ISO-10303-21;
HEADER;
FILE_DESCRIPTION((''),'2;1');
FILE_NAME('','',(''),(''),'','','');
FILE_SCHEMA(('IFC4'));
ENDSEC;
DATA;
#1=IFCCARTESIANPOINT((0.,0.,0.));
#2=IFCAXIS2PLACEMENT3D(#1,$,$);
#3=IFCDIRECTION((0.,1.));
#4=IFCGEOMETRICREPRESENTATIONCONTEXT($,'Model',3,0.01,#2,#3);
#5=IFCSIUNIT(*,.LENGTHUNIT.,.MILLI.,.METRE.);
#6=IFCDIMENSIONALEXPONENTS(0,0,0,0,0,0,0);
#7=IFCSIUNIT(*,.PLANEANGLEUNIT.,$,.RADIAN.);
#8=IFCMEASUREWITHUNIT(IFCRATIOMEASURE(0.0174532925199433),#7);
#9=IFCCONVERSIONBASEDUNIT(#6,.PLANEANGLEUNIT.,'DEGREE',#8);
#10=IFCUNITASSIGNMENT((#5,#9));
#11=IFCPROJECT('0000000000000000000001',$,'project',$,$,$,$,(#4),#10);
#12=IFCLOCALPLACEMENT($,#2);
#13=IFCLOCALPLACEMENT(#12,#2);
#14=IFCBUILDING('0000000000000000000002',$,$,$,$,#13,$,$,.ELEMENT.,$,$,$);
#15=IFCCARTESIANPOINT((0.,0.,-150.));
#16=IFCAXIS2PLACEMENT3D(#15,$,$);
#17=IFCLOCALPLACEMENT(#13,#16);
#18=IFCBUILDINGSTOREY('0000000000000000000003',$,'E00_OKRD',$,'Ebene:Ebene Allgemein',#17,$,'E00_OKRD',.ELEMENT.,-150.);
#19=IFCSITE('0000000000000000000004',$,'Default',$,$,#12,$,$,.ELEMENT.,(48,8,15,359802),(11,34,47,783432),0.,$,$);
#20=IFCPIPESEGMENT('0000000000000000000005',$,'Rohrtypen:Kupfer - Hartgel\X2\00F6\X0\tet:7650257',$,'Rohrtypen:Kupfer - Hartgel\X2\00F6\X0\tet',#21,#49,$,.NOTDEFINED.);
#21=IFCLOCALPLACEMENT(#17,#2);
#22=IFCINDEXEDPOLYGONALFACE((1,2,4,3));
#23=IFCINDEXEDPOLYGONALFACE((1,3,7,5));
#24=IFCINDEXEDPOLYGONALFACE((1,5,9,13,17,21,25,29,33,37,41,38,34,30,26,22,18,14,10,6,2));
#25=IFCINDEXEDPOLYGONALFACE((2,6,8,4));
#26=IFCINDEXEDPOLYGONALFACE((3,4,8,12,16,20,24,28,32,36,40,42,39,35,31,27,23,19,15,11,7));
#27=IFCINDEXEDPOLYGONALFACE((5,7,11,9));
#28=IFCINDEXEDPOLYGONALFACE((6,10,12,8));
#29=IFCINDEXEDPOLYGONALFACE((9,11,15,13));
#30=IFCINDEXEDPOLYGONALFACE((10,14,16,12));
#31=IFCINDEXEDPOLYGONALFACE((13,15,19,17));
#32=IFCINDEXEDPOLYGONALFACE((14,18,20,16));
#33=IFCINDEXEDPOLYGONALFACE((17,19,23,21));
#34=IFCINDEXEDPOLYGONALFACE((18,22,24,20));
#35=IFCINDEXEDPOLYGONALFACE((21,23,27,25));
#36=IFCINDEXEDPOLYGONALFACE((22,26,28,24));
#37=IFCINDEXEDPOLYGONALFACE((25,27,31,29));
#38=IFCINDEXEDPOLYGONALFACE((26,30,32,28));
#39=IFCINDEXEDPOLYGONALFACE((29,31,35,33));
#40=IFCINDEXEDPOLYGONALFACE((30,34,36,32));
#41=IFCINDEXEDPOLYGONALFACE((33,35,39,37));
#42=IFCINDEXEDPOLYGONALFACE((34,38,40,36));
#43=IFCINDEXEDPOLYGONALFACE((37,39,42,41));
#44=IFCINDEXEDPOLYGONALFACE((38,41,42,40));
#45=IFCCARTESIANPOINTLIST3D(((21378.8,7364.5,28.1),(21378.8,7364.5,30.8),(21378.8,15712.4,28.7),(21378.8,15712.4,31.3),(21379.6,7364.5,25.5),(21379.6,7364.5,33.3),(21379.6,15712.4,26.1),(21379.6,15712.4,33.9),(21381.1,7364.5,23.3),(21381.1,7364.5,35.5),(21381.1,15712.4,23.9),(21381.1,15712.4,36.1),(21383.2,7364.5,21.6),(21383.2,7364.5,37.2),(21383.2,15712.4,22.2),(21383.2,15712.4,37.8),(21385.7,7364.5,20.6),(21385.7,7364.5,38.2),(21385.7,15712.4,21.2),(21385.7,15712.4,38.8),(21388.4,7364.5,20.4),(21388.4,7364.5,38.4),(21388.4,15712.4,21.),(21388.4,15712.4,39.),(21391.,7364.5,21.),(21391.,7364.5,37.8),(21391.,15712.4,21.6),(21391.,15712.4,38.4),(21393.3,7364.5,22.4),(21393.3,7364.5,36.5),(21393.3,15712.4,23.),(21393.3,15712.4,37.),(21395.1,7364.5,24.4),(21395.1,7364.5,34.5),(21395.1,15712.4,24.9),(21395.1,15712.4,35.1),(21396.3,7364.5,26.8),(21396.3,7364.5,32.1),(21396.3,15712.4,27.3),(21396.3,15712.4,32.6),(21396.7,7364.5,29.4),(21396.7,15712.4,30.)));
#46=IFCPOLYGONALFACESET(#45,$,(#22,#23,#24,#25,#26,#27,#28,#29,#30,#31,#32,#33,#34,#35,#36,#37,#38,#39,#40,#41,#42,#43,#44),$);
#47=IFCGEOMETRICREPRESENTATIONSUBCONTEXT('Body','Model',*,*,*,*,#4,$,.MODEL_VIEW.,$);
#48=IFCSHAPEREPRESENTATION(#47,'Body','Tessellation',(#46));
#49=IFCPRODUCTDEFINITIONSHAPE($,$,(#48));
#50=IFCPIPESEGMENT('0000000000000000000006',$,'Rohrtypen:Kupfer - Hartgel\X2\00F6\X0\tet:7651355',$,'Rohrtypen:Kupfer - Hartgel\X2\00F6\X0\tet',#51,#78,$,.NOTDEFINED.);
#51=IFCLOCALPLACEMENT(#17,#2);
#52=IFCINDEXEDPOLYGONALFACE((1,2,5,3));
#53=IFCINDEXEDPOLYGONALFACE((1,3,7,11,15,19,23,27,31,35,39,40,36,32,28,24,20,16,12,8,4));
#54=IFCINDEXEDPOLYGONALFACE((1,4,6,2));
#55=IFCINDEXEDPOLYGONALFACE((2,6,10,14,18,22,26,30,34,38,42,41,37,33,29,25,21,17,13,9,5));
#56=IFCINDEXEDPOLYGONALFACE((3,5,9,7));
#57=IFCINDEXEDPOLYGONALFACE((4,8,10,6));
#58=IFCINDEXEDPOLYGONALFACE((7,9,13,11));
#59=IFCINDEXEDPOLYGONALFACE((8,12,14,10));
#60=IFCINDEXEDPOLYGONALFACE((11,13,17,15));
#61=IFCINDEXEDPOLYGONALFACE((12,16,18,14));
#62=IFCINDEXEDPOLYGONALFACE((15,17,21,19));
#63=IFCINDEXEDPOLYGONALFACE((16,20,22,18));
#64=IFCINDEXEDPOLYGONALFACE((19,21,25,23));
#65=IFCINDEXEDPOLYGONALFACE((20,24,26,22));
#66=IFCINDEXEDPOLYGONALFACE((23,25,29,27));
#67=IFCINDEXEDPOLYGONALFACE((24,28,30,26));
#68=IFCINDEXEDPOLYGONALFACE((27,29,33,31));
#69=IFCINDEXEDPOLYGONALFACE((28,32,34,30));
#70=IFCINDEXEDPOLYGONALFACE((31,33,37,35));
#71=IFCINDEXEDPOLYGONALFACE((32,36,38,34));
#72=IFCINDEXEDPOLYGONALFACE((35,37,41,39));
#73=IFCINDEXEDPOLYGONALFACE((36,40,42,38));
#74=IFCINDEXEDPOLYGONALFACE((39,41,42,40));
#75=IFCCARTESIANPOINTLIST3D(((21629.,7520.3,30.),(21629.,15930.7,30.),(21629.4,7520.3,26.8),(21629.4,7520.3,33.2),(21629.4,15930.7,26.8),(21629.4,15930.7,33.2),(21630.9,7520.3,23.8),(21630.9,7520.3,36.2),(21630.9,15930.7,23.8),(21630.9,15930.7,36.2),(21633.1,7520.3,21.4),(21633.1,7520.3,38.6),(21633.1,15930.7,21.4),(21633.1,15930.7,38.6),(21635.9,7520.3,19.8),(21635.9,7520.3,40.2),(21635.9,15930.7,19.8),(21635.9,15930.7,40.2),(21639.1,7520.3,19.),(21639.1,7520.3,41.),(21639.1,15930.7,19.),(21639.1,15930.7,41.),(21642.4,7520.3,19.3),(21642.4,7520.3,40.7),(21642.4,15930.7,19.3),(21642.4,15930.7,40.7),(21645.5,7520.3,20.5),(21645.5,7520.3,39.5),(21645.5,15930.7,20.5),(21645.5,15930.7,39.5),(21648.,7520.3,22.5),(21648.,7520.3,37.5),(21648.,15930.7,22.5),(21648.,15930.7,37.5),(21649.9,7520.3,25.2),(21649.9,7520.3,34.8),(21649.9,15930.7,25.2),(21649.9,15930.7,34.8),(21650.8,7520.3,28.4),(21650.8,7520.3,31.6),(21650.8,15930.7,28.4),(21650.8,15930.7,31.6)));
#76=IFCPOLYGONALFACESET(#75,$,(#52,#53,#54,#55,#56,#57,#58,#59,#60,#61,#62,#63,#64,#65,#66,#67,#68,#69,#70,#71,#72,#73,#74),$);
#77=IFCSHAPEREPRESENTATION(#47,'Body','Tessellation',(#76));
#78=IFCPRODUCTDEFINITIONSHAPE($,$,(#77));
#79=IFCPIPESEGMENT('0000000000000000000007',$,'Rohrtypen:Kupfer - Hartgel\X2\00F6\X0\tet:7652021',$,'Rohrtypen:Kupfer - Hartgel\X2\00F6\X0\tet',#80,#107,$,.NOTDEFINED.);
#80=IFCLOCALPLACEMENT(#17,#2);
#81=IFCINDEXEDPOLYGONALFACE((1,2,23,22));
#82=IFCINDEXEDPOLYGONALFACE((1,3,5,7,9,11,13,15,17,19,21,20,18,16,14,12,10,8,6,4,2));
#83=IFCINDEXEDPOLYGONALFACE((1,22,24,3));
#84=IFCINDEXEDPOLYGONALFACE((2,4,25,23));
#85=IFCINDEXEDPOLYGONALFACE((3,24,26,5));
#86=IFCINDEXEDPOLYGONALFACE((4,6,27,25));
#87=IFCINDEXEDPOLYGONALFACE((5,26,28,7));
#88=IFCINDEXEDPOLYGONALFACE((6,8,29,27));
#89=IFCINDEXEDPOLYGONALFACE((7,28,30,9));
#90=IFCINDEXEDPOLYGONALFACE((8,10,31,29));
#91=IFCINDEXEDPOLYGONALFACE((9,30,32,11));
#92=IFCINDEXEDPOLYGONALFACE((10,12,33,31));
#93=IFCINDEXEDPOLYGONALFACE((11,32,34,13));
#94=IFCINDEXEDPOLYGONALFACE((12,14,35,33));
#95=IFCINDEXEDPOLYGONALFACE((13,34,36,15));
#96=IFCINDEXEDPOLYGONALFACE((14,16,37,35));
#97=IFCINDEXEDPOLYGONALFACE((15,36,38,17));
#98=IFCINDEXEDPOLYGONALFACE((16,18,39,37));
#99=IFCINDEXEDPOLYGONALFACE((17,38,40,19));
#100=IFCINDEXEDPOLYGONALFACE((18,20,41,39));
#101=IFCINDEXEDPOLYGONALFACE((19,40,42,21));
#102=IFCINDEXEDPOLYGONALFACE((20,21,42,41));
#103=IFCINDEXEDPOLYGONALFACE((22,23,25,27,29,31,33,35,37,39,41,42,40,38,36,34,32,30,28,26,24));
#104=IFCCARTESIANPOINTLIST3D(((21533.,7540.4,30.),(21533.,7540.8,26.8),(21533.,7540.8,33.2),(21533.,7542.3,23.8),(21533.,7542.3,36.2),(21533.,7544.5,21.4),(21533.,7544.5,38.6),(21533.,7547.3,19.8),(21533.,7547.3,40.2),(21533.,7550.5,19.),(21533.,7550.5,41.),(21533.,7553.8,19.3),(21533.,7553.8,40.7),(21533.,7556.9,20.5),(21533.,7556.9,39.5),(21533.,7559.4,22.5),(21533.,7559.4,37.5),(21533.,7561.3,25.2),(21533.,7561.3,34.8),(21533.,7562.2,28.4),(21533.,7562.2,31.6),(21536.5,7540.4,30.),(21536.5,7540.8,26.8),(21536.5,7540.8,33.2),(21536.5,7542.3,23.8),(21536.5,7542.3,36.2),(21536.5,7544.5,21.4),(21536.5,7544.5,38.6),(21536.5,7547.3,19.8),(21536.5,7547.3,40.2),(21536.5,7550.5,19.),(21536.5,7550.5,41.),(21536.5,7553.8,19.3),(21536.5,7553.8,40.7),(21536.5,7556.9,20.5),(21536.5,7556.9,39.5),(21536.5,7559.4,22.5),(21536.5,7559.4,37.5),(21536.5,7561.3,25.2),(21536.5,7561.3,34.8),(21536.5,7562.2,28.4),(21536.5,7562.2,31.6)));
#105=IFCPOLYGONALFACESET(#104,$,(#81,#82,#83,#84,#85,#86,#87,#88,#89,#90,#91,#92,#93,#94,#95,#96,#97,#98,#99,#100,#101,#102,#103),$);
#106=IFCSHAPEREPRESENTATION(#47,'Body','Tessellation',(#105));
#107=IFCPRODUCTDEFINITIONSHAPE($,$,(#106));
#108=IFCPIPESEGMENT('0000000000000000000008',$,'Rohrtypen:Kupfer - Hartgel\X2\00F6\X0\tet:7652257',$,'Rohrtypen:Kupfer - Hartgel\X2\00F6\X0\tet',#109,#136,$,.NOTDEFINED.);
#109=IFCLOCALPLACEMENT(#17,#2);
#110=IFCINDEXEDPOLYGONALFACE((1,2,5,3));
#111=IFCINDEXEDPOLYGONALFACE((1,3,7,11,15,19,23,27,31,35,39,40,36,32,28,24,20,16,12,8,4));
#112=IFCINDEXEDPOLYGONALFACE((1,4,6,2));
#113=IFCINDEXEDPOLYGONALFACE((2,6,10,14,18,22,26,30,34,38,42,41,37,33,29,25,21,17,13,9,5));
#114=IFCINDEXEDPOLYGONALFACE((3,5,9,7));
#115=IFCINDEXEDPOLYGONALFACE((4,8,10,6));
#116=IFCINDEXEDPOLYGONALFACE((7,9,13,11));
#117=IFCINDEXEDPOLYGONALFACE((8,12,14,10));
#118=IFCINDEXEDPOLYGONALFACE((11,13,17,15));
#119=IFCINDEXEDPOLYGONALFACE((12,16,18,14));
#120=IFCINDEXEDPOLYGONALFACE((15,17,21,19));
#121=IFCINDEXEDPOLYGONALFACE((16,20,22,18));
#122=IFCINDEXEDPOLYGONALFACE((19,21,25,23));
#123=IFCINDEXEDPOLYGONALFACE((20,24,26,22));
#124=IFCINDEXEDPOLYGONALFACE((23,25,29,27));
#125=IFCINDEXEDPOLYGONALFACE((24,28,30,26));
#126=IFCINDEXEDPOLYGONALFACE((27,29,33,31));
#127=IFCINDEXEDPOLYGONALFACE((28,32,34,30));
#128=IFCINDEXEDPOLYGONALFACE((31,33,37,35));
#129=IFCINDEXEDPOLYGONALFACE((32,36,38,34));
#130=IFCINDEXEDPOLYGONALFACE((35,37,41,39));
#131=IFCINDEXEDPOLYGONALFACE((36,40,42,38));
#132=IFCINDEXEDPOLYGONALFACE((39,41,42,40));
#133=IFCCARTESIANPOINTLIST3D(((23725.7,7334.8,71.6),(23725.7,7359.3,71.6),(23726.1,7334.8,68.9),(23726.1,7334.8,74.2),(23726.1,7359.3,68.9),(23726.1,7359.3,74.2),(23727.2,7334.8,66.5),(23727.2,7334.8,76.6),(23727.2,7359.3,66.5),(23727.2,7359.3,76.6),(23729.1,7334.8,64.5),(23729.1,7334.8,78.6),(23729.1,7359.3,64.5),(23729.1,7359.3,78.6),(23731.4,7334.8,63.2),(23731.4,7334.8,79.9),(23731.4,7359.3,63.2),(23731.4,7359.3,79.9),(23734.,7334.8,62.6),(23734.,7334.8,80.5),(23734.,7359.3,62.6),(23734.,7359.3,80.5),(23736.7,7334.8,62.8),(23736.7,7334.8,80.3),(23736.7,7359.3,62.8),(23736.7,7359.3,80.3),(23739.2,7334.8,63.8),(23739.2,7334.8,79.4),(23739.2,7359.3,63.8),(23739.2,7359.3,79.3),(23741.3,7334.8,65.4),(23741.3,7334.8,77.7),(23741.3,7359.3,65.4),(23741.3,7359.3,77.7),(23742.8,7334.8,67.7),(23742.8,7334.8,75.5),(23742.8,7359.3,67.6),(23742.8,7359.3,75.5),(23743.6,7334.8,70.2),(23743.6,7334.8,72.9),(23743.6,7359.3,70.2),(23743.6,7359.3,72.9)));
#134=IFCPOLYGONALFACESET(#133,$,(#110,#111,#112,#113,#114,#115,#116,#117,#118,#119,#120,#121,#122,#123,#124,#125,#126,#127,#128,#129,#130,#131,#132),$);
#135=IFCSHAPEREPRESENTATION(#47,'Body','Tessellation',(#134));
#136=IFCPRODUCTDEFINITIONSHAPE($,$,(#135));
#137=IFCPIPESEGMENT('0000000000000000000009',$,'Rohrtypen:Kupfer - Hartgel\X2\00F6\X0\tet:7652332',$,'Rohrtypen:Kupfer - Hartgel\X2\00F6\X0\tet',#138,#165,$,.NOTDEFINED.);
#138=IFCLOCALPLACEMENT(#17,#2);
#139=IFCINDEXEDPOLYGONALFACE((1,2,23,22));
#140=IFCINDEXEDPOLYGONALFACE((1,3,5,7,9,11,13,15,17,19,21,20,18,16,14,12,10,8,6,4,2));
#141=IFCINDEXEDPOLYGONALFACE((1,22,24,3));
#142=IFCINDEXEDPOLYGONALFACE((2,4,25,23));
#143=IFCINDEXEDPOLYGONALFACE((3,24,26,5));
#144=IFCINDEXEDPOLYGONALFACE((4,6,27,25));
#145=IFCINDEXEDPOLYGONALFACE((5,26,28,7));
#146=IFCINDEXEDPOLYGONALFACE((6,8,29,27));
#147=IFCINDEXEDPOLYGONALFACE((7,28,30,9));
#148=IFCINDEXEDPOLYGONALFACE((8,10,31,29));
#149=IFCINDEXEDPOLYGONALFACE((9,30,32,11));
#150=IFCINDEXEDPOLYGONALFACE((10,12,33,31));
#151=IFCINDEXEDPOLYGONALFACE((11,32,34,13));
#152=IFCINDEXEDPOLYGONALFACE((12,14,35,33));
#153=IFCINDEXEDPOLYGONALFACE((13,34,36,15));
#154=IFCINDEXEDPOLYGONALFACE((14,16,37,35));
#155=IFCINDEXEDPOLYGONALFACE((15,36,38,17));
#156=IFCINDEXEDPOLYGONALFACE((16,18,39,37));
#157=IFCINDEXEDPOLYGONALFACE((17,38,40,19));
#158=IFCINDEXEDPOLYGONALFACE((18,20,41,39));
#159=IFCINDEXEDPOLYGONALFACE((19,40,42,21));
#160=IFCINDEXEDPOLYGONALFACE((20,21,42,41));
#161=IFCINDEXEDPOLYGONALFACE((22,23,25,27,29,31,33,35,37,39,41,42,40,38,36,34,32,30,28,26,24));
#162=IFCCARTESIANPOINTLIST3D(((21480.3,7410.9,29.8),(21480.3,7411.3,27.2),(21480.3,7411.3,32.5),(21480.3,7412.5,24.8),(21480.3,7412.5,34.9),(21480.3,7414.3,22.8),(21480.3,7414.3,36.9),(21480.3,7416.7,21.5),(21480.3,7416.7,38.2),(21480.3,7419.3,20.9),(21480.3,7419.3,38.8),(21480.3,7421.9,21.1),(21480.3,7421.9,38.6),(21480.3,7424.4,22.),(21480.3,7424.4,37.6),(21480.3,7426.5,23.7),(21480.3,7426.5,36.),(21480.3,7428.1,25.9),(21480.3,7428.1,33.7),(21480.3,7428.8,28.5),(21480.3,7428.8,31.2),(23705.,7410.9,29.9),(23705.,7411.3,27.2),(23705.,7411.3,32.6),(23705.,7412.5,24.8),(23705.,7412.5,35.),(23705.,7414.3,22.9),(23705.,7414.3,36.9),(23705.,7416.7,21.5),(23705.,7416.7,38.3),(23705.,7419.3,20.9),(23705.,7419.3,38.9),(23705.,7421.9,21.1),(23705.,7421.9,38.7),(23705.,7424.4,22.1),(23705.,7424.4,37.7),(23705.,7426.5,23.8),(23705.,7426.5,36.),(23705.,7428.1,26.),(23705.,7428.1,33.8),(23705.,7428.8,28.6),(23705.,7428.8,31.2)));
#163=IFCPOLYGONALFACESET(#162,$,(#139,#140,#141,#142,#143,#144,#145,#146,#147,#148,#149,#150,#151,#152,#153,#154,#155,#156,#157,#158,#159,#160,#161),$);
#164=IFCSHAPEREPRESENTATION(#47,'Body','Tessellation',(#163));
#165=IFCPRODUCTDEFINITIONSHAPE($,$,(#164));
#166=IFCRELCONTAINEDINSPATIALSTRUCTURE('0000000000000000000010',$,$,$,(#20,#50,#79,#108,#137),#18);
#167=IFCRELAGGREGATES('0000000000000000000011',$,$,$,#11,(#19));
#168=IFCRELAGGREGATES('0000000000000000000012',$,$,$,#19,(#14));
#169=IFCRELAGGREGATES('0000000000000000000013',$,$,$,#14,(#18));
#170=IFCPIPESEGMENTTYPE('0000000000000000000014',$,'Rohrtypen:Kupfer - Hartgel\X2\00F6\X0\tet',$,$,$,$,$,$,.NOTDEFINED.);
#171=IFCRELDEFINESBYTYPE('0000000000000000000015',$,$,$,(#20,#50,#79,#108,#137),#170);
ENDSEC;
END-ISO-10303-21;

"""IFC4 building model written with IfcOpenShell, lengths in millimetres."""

from ifc_helpers import new_model, entity, si_unit, converted_unit, direction, frame, frame_2d, origin, origin_2d_with_axis, place, context, subcontext, project, spatial, circle, extrude, type_object, element, save


model = new_model("IFC4")

# Units and contexts
model_context = context("Model", 3, precision=0.01, world=origin(), true_north=direction((0.0, 1.0)))
body_context = subcontext(model_context, "Body", "Model", "MODEL_VIEW")
ifc_project = project(units=[si_unit("LENGTHUNIT", "METRE", prefix="MILLI"), converted_unit("PLANEANGLEUNIT", "DEGREE", entity("IfcRatioMeasure", 0.0174532925199433), si_unit("PLANEANGLEUNIT", "RADIAN"), dimensions=[0, 0, 0, 0, 0, 0, 0])], contexts=[model_context])

# Site, building, storey
site_placement = place(None, origin())
site = spatial("IfcSite", under=ifc_project, at=site_placement, Name="Default", CompositionType="ELEMENT", RefLatitude=(48, 8, 15, 359802), RefLongitude=(11, 34, 47, 783432), RefElevation=0.0)
building_placement = place(site_placement, origin())
building = spatial("IfcBuilding", under=site, at=building_placement, CompositionType="ELEMENT")
storey_placement = place(building_placement, frame((0.0, 0.0, -150.0)))
storey = spatial("IfcBuildingStorey", under=building, at=storey_placement, Name="E00_OKRD", ObjectType="Ebene:Ebene Allgemein", LongName="E00_OKRD", CompositionType="ELEMENT", Elevation=-150.0)

# Pipe segments
pipe_segment_type = type_object("IfcPipeSegmentType", Name="Rohrtypen:Kupfer - Hartgelötet", PredefinedType="NOTDEFINED")
pipe_segment_1_placement = place(storey_placement, frame((21377.1, 7364.5, 18.8)))
element("IfcPipeSegment", 1, at=pipe_segment_1_placement, inside=storey, type_object=pipe_segment_type, Name="Rohrtypen:Kupfer - Hartgelötet:7650257", ObjectType="Rohrtypen:Kupfer - Hartgelötet", PredefinedType="NOTDEFINED", context=body_context, shape_type="SweptSolid", body=[
    extrude(circle(Radius=9.0, at=origin_2d_with_axis()), frame((10.6, 0.0, 10.6), z_axis=(0.0, 1.0, 0.000069), x_axis=(1.0, 0.0, 0.0)), (0.0, 0.0, 1.0), 8347.9),
])
pipe_segment_2_placement = place(storey_placement, frame((21627.4, 7520.3, 17.4)))
element("IfcPipeSegment", 2, at=pipe_segment_2_placement, inside=storey, type_object=pipe_segment_type, Name="Rohrtypen:Kupfer - Hartgelötet:7651355", ObjectType="Rohrtypen:Kupfer - Hartgelötet", PredefinedType="NOTDEFINED", context=body_context, shape_type="SweptSolid", body=[
    extrude(circle(Radius=11.0, at=frame_2d((0.0, 0.0), x_axis=(1.0, 0.0))), frame((12.6, 0.0, 12.6), z_axis=(0.0, 1.0, 0.0), x_axis=(-1.0, 0.0, 0.0)), (0.0, 0.0, 1.0), 8410.4),
])
pipe_segment_3_placement = place(storey_placement, frame((21533.0, 7538.8, 17.4)))
element("IfcPipeSegment", 3, at=pipe_segment_3_placement, inside=storey, type_object=pipe_segment_type, Name="Rohrtypen:Kupfer - Hartgelötet:7652021", ObjectType="Rohrtypen:Kupfer - Hartgelötet", PredefinedType="NOTDEFINED", context=body_context, shape_type="SweptSolid", body=[
    extrude(circle(Radius=11.0, at=origin_2d_with_axis()), frame((0.0, 12.6, 12.6), z_axis=(1.0, 0.0, 0.0), x_axis=(0.0, -1.0, 0.0)), (0.0, 0.0, 1.0), 3.5),
])
pipe_segment_4_placement = place(storey_placement, frame((23724.1, 7334.8, 61.0)))
element("IfcPipeSegment", 4, at=pipe_segment_4_placement, inside=storey, type_object=pipe_segment_type, Name="Rohrtypen:Kupfer - Hartgelötet:7652257", ObjectType="Rohrtypen:Kupfer - Hartgelötet", PredefinedType="NOTDEFINED", context=body_context, shape_type="SweptSolid", body=[
    extrude(circle(Radius=9.0, at=origin_2d_with_axis()), frame((10.6, 24.6, 10.6), z_axis=(0.0, -1.0, 0.000282), x_axis=(-1.0, 0.0, 0.0)), (0.0, 0.0, 1.0), 24.6),
])
pipe_segment_5_placement = place(storey_placement, frame((21480.3, 7409.3, 19.2)))
element("IfcPipeSegment", 5, at=pipe_segment_5_placement, inside=storey, type_object=pipe_segment_type, Name="Rohrtypen:Kupfer - Hartgelötet:7652332", ObjectType="Rohrtypen:Kupfer - Hartgelötet", PredefinedType="NOTDEFINED", context=body_context, shape_type="SweptSolid", body=[
    extrude(circle(Radius=9.0, at=frame_2d((0.0, 0.0), x_axis=(1.0, 0.0))), frame((0.0, 10.6, 10.6), z_axis=(1.0, 0.0, 0.000027), x_axis=(0.0, -1.0, 0.0)), (0.0, 0.0, 1.0), 2224.7),
])

save(model, "model.ifc")
